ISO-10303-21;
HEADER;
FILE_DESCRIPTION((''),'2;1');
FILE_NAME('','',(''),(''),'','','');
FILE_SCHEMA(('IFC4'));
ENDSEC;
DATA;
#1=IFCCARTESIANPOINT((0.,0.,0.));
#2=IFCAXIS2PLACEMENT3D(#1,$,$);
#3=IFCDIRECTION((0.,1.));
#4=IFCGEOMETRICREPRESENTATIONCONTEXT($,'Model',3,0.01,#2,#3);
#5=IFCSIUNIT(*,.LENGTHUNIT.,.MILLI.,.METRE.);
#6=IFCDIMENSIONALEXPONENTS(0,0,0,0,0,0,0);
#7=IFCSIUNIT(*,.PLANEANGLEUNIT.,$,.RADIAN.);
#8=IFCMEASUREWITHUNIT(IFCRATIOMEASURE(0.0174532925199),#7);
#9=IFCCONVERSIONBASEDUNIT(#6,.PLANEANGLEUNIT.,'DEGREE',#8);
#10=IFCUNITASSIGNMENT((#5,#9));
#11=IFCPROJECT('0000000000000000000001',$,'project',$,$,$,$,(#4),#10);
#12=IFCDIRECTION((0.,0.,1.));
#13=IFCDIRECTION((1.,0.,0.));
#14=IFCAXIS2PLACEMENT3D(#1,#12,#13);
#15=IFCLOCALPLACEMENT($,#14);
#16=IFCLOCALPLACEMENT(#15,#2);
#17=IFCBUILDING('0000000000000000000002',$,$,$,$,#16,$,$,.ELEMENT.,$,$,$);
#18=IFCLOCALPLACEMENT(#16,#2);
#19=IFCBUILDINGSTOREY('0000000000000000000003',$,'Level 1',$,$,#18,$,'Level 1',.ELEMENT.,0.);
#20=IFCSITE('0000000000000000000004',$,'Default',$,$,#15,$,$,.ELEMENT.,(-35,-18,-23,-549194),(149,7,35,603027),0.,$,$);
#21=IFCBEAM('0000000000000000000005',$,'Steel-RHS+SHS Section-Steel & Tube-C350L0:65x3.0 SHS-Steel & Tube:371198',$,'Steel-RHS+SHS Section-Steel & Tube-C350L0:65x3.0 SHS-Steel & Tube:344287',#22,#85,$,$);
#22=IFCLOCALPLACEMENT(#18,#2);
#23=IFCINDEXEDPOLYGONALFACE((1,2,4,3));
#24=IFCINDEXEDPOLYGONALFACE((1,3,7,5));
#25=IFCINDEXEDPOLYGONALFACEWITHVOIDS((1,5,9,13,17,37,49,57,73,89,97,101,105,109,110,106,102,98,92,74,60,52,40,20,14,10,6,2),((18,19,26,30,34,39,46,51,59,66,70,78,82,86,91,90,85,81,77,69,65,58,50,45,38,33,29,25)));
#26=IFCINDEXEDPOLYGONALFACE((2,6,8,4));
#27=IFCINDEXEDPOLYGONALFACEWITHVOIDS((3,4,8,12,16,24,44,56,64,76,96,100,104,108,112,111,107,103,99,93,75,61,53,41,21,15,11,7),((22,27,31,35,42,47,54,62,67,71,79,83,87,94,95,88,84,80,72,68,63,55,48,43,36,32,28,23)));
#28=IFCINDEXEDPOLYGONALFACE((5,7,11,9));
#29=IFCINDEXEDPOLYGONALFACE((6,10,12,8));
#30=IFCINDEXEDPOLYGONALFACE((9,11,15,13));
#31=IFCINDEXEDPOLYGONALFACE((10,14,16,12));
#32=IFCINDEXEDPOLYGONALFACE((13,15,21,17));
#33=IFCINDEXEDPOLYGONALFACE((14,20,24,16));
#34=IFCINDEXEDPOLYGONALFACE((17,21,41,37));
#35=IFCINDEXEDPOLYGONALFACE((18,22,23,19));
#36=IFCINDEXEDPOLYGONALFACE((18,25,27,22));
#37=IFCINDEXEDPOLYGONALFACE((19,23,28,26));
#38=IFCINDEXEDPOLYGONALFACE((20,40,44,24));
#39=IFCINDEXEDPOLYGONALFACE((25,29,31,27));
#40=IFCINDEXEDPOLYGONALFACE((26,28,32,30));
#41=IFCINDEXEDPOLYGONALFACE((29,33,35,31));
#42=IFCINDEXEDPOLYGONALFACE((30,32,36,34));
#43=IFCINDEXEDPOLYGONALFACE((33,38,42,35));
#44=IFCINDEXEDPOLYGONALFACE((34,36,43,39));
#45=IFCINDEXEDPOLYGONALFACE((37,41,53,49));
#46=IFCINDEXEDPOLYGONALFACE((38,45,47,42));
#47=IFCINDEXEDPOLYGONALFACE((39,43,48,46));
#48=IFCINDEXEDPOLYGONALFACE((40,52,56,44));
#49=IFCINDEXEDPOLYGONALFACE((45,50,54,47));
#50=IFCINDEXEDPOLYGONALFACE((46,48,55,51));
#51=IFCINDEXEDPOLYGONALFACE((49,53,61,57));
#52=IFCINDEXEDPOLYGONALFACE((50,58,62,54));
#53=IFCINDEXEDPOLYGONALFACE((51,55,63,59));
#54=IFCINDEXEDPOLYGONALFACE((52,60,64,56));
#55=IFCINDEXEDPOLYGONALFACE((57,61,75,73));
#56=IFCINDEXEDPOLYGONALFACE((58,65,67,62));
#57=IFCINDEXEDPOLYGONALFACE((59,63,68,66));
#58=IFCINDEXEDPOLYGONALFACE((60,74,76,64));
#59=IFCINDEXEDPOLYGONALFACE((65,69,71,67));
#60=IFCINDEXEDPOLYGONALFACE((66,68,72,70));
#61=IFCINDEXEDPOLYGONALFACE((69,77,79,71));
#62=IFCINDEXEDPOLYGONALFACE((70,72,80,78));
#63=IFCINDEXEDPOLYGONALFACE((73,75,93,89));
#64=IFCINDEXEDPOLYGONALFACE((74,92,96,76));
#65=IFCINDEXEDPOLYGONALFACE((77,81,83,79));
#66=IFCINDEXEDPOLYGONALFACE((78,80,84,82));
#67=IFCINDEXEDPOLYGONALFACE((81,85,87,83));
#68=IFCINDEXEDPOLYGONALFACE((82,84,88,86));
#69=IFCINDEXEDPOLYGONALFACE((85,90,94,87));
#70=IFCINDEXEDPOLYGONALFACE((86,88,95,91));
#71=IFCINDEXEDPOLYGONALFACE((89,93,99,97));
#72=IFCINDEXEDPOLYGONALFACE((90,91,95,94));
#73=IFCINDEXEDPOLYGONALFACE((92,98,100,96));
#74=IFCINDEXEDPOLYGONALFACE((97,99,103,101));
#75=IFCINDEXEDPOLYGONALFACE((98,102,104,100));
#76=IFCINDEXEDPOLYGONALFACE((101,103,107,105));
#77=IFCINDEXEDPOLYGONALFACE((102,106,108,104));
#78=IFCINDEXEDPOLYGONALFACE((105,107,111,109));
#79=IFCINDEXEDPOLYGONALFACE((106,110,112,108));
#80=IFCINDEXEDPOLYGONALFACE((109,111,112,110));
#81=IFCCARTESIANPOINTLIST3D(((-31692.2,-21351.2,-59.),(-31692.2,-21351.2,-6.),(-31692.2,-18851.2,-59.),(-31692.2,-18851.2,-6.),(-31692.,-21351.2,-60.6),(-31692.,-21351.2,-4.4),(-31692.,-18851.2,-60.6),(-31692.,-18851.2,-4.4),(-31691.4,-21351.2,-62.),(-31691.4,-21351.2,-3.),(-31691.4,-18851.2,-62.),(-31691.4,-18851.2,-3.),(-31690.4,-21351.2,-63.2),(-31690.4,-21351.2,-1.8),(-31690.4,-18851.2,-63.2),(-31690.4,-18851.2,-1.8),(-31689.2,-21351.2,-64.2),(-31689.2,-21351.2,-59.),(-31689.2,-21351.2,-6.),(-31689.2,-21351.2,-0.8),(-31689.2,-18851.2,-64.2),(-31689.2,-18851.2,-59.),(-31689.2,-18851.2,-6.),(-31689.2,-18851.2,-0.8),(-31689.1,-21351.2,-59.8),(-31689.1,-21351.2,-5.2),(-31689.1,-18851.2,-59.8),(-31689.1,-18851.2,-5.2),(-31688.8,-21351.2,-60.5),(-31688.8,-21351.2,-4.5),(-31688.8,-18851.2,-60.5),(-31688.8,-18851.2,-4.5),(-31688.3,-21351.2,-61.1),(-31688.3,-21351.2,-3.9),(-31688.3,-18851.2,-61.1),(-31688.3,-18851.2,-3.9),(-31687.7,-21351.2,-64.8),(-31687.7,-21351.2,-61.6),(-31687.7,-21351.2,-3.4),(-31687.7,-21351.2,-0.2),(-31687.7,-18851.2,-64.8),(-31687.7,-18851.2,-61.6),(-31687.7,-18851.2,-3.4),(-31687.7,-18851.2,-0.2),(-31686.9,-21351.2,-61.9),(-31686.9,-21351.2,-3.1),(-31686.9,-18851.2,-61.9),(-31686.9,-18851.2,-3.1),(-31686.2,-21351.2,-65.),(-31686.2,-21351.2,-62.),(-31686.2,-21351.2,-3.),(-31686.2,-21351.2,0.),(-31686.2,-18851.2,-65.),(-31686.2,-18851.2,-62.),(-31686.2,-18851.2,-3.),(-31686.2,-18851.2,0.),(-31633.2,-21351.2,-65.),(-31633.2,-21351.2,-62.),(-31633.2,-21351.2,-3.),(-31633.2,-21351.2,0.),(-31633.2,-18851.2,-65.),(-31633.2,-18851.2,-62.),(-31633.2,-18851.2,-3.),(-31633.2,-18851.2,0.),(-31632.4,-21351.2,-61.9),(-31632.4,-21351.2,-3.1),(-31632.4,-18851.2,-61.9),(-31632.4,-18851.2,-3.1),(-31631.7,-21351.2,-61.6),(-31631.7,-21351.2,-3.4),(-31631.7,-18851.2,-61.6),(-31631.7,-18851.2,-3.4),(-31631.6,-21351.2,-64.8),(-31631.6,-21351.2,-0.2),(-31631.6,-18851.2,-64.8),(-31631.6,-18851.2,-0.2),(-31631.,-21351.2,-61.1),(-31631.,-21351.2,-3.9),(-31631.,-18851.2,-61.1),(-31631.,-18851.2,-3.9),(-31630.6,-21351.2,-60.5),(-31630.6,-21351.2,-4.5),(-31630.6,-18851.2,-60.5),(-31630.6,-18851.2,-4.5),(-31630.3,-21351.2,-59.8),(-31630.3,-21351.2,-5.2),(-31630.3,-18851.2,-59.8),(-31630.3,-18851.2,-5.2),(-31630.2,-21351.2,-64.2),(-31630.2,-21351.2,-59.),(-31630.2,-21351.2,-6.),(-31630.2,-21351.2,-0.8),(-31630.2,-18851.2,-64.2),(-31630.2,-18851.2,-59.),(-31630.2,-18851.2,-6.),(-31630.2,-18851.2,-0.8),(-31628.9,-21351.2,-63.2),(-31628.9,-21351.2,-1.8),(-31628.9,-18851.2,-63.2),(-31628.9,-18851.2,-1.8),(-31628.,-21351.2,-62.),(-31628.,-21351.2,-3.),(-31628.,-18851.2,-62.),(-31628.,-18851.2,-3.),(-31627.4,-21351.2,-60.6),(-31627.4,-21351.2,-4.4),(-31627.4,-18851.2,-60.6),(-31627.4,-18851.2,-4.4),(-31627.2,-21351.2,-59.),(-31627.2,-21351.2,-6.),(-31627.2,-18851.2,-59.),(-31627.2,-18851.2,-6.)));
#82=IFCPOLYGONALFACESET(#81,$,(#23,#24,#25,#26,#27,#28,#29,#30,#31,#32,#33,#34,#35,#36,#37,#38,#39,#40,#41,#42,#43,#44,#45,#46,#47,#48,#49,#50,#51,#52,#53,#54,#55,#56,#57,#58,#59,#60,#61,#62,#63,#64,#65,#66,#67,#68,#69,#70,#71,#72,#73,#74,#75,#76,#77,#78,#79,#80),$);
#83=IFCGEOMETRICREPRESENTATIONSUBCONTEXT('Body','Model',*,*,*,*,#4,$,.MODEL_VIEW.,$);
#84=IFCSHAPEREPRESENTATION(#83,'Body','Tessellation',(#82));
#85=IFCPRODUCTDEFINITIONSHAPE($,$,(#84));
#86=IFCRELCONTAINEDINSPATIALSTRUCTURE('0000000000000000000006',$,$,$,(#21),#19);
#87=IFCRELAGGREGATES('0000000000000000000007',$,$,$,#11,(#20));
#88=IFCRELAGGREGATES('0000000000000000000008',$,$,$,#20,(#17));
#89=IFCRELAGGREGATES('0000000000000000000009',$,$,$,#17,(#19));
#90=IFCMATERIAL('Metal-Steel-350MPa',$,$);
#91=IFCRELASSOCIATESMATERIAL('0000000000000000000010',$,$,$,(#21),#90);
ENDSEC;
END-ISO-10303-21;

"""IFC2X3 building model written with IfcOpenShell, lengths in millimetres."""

from ifc_helpers import new_model, entity, si_unit, converted_unit, direction, frame, frame_2d, origin, origin_with_axes, place, context, subcontext, project, spatial, polyline, circle_curve, parameter, trimmed, segment, composite_curve, outline, extrude, material, element, save


model = new_model("IFC2X3")

# Units and contexts
model_context = context("Model", 3, precision=0.01, world=origin(), true_north=direction((0.0, 1.0)))
body_context = subcontext(model_context, "Body", "Model", "MODEL_VIEW")
ifc_project = project(units=[si_unit("LENGTHUNIT", "METRE", prefix="MILLI"), converted_unit("PLANEANGLEUNIT", "DEGREE", entity("IfcRatioMeasure", 0.0174532925199), si_unit("PLANEANGLEUNIT", "RADIAN"), dimensions=[0, 0, 0, 0, 0, 0, 0])], contexts=[model_context])

# Site, building, storey
site_placement = place(None, origin_with_axes())
site = spatial("IfcSite", under=ifc_project, at=site_placement, Name="Default", CompositionType="ELEMENT", RefLatitude=(-35, -18, -23, -549194), RefLongitude=(149, 7, 35, 603027), RefElevation=0.0)
building_placement = place(site_placement, origin())
building = spatial("IfcBuilding", under=site, at=building_placement, CompositionType="ELEMENT")
storey_placement = place(building_placement, origin())
storey = spatial("IfcBuildingStorey", under=building, at=storey_placement, Name="Level 1", LongName="Level 1", CompositionType="ELEMENT", Elevation=0.0)

# Beam
ifc_material = material(Name="Metal-Steel-350MPa")
beam_1_placement = place(storey_placement, frame((-31659.7, -18851.2, 0.0), z_axis=(0.0, 0.0, 1.0), x_axis=(0.0, -1.0, 0.0)))
element("IfcBeam", 1, at=beam_1_placement, inside=storey, material=ifc_material, Name="Steel-RHS+SHS Section-Steel & Tube-C350L0:65x3.0 SHS-Steel & Tube:371198", ObjectType="Steel-RHS+SHS Section-Steel & Tube-C350L0:65x3.0 SHS-Steel & Tube:344287", context=body_context, shape_type="SweptSolid", body=[
    extrude(outline(composite_curve([segment(trimmed(circle_curve(frame_2d((-26.5, -26.5), x_axis=(1.0, 0.0)), 6.0), [parameter(180.0)], [parameter(270.0)], True, "PARAMETER"), True, "CONTINUOUS"), segment(polyline([(-26.5, -32.5), (26.5, -32.5)]), True, "CONTINUOUS"), segment(trimmed(circle_curve(frame_2d((26.5, -26.5), x_axis=(1.0, 0.0)), 6.0), [parameter(270.0)], [parameter(0.0)], True, "PARAMETER"), True, "CONTINUOUS"), segment(polyline([(32.5, -26.5), (32.5, 26.5)]), True, "CONTINUOUS"), segment(trimmed(circle_curve(frame_2d((26.5, 26.5), x_axis=(1.0, 0.0)), 6.0), [parameter(0.0)], [parameter(90.0)], True, "PARAMETER"), True, "CONTINUOUS"), segment(polyline([(26.5, 32.5), (-26.5, 32.5)]), True, "CONTINUOUS"), segment(trimmed(circle_curve(frame_2d((-26.5, 26.5), x_axis=(1.0, 0.0)), 6.0), [parameter(90.0)], [parameter(180.0)], True, "PARAMETER"), True, "CONTINUOUS"), segment(polyline([(-32.5, 26.5), (-32.5, -26.5)]), True, "CONTINUOUS")], self_intersect=False), holes=[composite_curve([segment(polyline([(26.5, -29.5), (-26.5, -29.5)]), True, "CONTINUOUS"), segment(trimmed(circle_curve(frame_2d((-26.5, -26.5), x_axis=(1.0, 0.0)), 3.0), [parameter(180.0)], [parameter(270.0)], True, "PARAMETER"), False, "CONTINUOUS"), segment(polyline([(-29.5, -26.5), (-29.5, 26.5)]), True, "CONTINUOUS"), segment(trimmed(circle_curve(frame_2d((-26.5, 26.5), x_axis=(1.0, 0.0)), 3.0), [parameter(90.0)], [parameter(180.0)], True, "PARAMETER"), False, "CONTINUOUS"), segment(polyline([(-26.5, 29.5), (26.5, 29.5)]), True, "CONTINUOUS"), segment(trimmed(circle_curve(frame_2d((26.5, 26.5), x_axis=(1.0, 0.0)), 3.0), [parameter(360.0)], [parameter(90.0)], True, "PARAMETER"), False, "CONTINUOUS"), segment(polyline([(29.5, 26.5), (29.5, -26.5)]), True, "CONTINUOUS"), segment(trimmed(circle_curve(frame_2d((26.5, -26.5), x_axis=(1.0, 0.0)), 3.0), [parameter(270.0)], [parameter(0.0)], True, "PARAMETER"), False, "CONTINUOUS")], self_intersect=False)]), frame((0.0, 0.0, -32.5), z_axis=(1.0, 0.0, 0.0), x_axis=(0.0, -1.0, 0.0)), (0.0, 0.0, 1.0), 2500.0),
])

save(model, "model.ifc")
